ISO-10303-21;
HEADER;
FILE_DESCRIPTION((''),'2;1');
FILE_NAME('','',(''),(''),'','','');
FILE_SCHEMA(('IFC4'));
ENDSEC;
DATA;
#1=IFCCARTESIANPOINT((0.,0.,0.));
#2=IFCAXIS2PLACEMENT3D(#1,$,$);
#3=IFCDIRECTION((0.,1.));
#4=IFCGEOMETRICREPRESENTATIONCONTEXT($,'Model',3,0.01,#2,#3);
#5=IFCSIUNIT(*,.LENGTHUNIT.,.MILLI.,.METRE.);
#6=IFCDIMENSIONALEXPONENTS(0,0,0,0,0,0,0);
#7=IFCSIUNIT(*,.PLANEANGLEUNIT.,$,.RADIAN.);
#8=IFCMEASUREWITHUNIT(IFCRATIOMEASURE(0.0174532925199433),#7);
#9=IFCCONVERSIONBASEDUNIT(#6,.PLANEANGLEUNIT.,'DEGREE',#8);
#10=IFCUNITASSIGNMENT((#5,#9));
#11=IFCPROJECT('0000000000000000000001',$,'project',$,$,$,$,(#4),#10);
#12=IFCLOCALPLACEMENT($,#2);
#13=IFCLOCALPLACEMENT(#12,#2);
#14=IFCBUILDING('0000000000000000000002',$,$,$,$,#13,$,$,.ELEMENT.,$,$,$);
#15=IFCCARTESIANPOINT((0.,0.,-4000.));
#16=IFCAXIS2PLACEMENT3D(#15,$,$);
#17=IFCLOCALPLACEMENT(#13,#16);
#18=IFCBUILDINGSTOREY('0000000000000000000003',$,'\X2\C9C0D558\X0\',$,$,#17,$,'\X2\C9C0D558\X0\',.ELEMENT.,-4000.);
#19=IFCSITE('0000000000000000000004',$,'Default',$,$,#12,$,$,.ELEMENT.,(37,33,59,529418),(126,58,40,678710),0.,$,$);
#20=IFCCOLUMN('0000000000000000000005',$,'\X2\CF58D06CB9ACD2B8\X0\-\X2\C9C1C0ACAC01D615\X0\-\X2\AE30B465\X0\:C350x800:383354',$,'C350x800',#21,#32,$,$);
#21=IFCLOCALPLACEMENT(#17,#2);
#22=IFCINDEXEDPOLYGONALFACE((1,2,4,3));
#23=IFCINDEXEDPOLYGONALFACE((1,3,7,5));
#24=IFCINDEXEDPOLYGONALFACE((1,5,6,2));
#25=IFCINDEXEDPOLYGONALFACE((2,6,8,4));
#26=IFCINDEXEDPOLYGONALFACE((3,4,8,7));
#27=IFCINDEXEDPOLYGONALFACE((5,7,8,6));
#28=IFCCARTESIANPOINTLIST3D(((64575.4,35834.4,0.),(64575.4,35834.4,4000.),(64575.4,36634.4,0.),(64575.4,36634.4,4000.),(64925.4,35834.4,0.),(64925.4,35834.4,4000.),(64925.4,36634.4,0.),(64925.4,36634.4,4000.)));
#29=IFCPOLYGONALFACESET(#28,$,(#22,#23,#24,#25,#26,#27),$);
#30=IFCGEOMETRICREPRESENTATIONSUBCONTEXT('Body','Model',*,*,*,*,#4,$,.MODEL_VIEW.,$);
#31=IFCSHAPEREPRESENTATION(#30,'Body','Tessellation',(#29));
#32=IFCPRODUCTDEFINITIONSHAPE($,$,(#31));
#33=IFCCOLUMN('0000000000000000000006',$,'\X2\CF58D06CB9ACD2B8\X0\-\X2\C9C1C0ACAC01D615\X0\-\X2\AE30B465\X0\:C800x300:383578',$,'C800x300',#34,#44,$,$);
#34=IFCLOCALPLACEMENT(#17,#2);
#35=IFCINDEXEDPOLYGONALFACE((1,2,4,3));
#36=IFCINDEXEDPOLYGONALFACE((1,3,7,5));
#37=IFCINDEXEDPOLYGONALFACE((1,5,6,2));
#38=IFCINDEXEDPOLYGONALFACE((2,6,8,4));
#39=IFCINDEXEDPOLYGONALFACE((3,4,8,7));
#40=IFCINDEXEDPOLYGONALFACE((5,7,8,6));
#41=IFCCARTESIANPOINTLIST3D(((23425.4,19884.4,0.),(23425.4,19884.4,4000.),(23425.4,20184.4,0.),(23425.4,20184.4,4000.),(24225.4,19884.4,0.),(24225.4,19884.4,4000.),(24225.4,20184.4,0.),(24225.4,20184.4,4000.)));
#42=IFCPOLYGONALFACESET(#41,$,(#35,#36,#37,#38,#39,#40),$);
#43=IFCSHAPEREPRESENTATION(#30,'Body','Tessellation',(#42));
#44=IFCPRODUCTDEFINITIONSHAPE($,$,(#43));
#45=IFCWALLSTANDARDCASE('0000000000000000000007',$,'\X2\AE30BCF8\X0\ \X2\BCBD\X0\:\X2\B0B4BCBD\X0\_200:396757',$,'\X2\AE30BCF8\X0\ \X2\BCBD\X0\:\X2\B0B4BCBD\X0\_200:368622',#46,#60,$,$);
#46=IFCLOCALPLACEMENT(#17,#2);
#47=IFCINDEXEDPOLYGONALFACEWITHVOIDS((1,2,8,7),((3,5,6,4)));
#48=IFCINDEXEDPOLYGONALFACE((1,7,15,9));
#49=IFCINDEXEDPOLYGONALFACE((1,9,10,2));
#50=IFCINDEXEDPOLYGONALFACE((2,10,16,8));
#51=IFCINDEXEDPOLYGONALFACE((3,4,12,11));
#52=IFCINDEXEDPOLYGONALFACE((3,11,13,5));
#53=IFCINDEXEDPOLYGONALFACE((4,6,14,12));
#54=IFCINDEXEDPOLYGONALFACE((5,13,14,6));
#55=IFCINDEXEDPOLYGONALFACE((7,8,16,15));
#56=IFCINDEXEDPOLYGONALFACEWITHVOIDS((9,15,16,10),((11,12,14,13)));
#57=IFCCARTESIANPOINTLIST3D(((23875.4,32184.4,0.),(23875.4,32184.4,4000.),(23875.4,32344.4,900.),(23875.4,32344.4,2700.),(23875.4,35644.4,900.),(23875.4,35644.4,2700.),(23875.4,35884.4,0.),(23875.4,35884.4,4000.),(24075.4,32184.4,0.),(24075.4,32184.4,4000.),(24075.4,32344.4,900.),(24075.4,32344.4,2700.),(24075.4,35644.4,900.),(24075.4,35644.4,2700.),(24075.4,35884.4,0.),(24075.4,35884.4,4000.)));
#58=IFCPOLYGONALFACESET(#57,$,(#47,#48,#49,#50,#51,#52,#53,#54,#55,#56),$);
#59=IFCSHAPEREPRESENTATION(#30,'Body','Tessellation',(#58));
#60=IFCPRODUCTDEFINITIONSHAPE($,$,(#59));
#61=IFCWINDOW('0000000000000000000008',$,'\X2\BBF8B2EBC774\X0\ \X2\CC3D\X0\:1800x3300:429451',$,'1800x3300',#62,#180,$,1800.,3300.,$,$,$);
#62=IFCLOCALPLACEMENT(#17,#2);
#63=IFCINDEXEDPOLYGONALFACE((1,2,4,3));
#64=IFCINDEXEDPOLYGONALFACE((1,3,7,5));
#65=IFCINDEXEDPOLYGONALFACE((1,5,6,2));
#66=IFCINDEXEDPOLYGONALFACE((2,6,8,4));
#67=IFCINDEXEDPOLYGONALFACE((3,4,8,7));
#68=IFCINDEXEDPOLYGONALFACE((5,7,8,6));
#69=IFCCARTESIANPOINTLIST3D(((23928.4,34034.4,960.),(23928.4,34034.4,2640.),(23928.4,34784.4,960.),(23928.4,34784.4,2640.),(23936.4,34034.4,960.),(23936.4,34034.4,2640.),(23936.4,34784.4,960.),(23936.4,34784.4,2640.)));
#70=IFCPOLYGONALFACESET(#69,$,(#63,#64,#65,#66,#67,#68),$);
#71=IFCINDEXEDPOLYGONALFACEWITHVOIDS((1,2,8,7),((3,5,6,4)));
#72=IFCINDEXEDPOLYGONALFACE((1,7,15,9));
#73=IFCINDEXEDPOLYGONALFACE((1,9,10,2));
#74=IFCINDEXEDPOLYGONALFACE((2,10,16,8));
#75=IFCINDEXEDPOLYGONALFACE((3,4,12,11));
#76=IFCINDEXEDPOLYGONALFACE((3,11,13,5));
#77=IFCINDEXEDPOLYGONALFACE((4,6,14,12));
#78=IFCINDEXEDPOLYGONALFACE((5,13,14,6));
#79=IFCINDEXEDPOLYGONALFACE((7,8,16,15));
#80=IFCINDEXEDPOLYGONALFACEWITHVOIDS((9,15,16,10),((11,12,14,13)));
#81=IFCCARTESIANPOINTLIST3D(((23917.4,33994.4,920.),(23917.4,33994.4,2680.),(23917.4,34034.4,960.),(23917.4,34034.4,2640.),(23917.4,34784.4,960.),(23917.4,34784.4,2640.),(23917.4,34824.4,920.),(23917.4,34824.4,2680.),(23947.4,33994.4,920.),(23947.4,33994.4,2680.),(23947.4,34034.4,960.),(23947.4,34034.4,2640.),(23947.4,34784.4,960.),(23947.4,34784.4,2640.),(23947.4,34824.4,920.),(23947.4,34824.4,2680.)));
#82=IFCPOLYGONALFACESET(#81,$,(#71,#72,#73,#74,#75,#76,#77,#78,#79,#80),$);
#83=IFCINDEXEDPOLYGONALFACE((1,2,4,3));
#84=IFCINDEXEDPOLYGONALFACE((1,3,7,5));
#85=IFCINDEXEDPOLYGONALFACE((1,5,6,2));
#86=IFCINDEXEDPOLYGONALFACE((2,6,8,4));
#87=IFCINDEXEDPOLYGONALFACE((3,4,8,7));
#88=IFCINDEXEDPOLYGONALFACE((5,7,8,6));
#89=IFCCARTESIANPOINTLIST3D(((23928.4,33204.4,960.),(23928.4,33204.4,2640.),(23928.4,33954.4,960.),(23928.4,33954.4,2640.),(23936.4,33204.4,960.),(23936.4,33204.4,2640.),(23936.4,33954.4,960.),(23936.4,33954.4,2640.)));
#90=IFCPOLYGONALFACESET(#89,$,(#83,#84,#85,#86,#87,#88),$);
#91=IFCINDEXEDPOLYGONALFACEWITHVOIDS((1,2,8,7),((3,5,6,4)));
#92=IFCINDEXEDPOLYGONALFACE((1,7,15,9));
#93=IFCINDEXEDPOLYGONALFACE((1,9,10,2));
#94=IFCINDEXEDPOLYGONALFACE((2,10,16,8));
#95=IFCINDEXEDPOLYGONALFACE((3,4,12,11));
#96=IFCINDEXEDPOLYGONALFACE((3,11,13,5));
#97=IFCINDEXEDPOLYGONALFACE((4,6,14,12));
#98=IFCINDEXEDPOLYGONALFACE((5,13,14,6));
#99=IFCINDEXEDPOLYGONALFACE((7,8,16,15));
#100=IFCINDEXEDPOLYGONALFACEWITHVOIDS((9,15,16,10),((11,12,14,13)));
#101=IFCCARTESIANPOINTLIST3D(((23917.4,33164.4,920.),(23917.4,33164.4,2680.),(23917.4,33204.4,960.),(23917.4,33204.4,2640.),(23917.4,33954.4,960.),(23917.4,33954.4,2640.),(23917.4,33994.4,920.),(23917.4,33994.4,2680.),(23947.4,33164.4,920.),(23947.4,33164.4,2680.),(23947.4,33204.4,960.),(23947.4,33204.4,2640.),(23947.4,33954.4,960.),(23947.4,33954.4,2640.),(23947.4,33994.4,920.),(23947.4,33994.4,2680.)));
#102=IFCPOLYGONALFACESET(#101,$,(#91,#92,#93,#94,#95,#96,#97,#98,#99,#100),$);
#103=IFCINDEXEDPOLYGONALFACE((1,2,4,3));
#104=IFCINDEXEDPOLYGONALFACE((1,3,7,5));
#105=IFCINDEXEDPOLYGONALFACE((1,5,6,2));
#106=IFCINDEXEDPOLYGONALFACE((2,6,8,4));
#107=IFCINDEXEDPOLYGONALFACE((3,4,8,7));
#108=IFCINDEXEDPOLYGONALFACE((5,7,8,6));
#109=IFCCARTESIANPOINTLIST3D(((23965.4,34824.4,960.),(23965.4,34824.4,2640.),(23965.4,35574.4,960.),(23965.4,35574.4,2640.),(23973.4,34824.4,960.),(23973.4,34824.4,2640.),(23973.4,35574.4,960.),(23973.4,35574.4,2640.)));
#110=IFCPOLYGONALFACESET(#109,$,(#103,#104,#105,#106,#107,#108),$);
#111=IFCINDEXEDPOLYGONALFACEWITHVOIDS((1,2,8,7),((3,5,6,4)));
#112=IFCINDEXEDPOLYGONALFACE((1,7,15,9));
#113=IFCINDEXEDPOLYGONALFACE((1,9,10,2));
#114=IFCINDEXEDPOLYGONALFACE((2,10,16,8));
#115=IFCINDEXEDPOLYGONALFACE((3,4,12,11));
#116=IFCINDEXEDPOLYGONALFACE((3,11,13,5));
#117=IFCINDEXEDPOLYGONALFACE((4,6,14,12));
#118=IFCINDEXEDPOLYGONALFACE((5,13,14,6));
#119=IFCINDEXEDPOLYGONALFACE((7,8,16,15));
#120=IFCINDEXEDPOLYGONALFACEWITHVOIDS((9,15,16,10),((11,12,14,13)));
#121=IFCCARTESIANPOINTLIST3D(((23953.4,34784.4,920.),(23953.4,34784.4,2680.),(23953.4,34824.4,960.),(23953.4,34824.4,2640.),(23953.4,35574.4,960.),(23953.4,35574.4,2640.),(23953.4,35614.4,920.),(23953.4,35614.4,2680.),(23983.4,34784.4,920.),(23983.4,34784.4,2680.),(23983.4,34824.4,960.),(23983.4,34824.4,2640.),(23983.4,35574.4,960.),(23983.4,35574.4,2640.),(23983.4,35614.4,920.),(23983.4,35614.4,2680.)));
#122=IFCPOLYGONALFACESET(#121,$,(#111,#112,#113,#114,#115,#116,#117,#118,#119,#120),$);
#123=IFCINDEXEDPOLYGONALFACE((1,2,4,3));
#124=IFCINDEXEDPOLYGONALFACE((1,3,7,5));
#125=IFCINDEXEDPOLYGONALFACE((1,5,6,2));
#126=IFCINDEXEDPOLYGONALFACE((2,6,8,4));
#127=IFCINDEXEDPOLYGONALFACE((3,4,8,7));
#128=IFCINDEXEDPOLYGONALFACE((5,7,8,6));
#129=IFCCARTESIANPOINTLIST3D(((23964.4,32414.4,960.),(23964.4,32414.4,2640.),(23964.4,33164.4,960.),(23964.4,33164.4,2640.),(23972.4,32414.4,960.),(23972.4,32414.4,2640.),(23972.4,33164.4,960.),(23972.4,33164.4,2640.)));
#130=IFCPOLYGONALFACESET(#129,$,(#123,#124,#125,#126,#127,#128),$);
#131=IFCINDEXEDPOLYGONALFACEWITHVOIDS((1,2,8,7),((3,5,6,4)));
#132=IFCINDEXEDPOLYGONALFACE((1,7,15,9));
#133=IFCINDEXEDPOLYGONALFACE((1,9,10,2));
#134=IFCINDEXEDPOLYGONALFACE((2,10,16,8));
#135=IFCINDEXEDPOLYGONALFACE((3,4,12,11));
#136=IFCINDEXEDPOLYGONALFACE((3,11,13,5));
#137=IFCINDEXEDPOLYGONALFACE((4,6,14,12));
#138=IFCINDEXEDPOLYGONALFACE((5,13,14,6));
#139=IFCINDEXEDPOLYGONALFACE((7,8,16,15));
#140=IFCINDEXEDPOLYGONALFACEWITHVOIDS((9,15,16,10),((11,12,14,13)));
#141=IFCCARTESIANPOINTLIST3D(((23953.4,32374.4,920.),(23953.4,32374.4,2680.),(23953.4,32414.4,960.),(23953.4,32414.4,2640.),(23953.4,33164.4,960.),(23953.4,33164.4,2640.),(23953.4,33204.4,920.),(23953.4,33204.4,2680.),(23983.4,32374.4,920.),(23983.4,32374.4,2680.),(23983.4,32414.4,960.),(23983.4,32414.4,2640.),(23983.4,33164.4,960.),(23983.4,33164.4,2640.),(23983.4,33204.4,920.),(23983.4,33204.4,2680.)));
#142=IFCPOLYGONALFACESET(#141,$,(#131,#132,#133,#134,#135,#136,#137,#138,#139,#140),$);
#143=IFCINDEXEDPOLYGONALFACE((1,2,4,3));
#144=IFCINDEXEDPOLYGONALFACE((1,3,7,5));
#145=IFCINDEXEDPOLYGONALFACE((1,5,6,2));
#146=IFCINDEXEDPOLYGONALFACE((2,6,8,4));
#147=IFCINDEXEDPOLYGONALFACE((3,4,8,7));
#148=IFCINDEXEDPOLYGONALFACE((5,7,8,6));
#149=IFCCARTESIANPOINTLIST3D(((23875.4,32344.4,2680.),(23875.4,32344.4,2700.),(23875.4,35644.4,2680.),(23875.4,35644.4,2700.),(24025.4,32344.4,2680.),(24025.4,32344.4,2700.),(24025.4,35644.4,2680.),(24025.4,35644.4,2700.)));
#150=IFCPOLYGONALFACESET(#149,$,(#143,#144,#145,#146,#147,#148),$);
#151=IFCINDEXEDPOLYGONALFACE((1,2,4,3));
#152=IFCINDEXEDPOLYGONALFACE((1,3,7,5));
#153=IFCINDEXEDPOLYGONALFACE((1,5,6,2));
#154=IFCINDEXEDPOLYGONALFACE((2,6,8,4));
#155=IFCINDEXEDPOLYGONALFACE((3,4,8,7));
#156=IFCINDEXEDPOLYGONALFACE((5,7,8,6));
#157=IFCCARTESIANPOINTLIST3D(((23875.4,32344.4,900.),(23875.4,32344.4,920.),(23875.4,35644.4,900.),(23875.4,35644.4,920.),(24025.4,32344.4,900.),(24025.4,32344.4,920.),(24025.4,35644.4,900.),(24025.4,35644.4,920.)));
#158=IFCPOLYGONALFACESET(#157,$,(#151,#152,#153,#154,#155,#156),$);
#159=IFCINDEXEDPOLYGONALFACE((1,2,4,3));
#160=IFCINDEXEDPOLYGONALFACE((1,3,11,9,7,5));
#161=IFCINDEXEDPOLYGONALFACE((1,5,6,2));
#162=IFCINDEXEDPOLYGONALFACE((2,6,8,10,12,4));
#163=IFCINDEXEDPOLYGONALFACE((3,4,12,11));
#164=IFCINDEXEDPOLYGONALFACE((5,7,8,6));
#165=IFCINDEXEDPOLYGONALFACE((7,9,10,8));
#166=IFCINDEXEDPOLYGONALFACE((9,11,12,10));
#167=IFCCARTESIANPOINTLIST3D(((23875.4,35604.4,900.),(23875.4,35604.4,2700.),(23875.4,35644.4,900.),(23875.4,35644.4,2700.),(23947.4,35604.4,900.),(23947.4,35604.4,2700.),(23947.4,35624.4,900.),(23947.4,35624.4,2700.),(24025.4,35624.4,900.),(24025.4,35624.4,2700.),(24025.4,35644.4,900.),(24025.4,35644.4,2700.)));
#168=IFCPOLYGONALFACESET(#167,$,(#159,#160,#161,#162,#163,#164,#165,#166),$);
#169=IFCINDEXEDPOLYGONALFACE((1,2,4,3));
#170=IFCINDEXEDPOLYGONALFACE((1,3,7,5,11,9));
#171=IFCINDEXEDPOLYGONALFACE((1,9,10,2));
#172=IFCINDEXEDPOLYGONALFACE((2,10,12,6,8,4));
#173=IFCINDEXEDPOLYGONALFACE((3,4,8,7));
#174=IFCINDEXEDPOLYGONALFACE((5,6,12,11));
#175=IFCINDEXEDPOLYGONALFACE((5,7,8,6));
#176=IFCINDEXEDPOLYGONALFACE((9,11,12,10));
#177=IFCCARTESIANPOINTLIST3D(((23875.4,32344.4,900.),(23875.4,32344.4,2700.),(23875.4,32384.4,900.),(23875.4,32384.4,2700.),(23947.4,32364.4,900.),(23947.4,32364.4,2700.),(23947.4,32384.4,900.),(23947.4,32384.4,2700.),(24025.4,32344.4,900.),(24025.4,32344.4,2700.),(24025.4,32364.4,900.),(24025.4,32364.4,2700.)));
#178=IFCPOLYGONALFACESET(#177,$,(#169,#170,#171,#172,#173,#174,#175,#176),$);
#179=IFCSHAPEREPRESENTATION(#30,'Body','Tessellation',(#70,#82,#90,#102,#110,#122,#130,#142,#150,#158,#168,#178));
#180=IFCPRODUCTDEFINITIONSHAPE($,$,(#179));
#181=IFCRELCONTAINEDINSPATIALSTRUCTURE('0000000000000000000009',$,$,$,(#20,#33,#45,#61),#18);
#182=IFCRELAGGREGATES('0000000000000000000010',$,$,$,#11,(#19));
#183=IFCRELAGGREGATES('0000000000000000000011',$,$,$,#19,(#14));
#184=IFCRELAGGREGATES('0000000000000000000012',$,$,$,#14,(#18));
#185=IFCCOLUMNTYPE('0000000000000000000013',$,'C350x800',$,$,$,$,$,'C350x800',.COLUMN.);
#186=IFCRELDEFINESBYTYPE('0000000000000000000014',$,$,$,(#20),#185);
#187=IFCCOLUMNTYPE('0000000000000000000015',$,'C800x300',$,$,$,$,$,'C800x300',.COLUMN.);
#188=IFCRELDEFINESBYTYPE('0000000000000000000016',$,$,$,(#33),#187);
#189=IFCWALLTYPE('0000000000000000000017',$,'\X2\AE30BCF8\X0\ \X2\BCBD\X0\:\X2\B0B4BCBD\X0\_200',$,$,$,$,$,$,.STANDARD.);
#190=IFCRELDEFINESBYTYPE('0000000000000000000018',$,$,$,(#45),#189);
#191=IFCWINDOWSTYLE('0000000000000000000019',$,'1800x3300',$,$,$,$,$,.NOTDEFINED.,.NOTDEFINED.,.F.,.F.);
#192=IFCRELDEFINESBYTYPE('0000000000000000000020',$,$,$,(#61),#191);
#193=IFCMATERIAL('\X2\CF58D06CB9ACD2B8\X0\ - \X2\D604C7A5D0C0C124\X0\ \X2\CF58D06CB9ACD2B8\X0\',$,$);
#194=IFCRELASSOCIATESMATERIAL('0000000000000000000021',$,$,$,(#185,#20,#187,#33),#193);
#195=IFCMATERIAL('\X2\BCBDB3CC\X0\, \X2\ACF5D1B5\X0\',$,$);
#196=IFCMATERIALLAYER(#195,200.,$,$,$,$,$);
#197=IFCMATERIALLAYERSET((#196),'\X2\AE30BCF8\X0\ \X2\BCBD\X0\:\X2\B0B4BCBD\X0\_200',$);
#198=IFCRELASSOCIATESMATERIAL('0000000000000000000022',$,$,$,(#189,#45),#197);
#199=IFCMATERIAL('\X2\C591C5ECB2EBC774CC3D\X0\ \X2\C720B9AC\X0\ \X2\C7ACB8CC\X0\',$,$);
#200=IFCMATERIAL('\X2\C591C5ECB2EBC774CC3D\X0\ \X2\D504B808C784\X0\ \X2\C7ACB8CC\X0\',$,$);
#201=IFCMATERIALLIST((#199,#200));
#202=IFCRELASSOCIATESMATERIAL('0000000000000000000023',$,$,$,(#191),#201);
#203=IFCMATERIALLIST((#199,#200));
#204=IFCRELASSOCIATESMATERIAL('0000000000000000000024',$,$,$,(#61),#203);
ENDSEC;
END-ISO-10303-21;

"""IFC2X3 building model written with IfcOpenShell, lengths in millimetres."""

from ifc_helpers import new_model, entity, si_unit, converted_unit, direction, frame, frame_2d, origin, origin_2d_with_axis, place, context, subcontext, project, spatial, polyline, rectangle, outline, extrude, source, transform, mapped, material, material_list, layer, layer_set, layer_usage, type_object, type_shapes, element, fill, save


model = new_model("IFC2X3")

# Units and contexts
model_context = context("Model", 3, precision=0.01, world=origin(), true_north=direction((0.0, 1.0)))
body_context = subcontext(model_context, "Body", "Model", "MODEL_VIEW")
ifc_project = project(units=[si_unit("LENGTHUNIT", "METRE", prefix="MILLI"), converted_unit("PLANEANGLEUNIT", "DEGREE", entity("IfcRatioMeasure", 0.0174532925199433), si_unit("PLANEANGLEUNIT", "RADIAN"), dimensions=[0, 0, 0, 0, 0, 0, 0])], contexts=[model_context])

# Site, building, storey
site_placement = place(None, origin())
site = spatial("IfcSite", under=ifc_project, at=site_placement, Name="Default", CompositionType="ELEMENT", RefLatitude=(37, 33, 59, 529418), RefLongitude=(126, 58, 40, 678710), RefElevation=0.0)
building_placement = place(site_placement, origin())
building = spatial("IfcBuilding", under=site, at=building_placement, CompositionType="ELEMENT")
storey_placement = place(building_placement, frame((0.0, 0.0, -4000.0)))
storey = spatial("IfcBuildingStorey", under=building, at=storey_placement, Name="지하", LongName="지하", CompositionType="ELEMENT", Elevation=-4000.0)

# Columns
ifc_material_1 = material(Name="콘크리트 - 현장타설 콘크리트")
column_type_1 = type_object("IfcColumnType", Name="C350x800", ElementType="C350x800", PredefinedType="COLUMN", material=ifc_material_1)
shared_shape_1 = source(origin(), body_context, "Body", "SweptSolid", [
    extrude(rectangle(XDim=800.0, YDim=350.0, at=frame_2d((0.0, 0.0), x_axis=(1.0, 0.0))), frame((64750.4, 36234.4, -4000.0), z_axis=(0.0, 0.0, 1.0), x_axis=(0.0, -1.0, 0.0)), (0.0, 0.0, 1.0), 4000.0),
])
type_shapes(column_type_1, [shared_shape_1])
column_1_placement = place(storey_placement, frame((0.0, 0.0, 4000.0)))
element("IfcColumn", 1, at=column_1_placement, inside=storey, type_object=column_type_1, material=ifc_material_1, Name="콘크리트-직사각형-기둥:C350x800:383354", ObjectType="C350x800", context=body_context, shape_type="MappedRepresentation", body=[
    mapped(shared_shape_1, transform((0.0, 0.0, 0.0), scale=1.0)),
])
column_type_2 = type_object("IfcColumnType", Name="C800x300", ElementType="C800x300", PredefinedType="COLUMN", material=ifc_material_1)
shared_shape_2 = source(origin(), body_context, "Body", "SweptSolid", [
    extrude(rectangle(XDim=300.0, YDim=800.0, at=origin_2d_with_axis()), frame((23825.4, 20034.4, -4000.0), z_axis=(0.0, 0.0, 1.0), x_axis=(0.0, -1.0, 0.0)), (0.0, 0.0, 1.0), 4000.0),
])
type_shapes(column_type_2, [shared_shape_2])
column_2_placement = place(storey_placement, frame((0.0, 0.0, 4000.0)))
element("IfcColumn", 2, at=column_2_placement, inside=storey, type_object=column_type_2, material=ifc_material_1, Name="콘크리트-직사각형-기둥:C800x300:383578", ObjectType="C800x300", context=body_context, shape_type="MappedRepresentation", body=[
    mapped(shared_shape_2, transform((0.0, 0.0, 0.0), scale=1.0)),
])

# Wall, opening, window
ifc_material_2 = material(Name="벽돌, 공통")
ifc_layer_1 = layer(ifc_material_2, 200.0)
ifc_layer_set_1 = layer_set([ifc_layer_1], Name="기본 벽:내벽_200")
ifc_layer_usage_1 = layer_usage(ifc_layer_set_1, "AXIS2", "NEGATIVE", 100.0)
wall_type_1 = type_object("IfcWallType", Name="기본 벽:내벽_200", PredefinedType="STANDARD", material=ifc_layer_set_1)
wall_1_placement = place(storey_placement, frame((23975.4, 35884.4, 0.0), z_axis=(0.0, 0.0, 1.0), x_axis=(0.0, -1.0, 0.0)))
wall_1 = element("IfcWallStandardCase", 3, at=wall_1_placement, inside=storey, type_object=wall_type_1, material=ifc_layer_usage_1, Name="기본 벽:내벽_200:396757", ObjectType="기본 벽:내벽_200:368622", context=body_context, shape_type="SweptSolid", body=[
    extrude(rectangle(XDim=3700.0, YDim=200.0, at=frame_2d((1850.0, 0.0), x_axis=(-1.0, 0.0))), origin(), (0.0, 0.0, 1.0), 4000.0),
])
opening_1_placement = place(wall_1_placement, frame((3540.0, 100.0, 900.0)))
opening_1 = element("IfcOpeningElement", 4, at=opening_1_placement, cuts=wall_1, ObjectType="Opening", context=body_context, shape_type="SweptSolid", body=[
    extrude(rectangle(XDim=1800.0, YDim=3300.0, at=frame_2d((900.0, 1650.0), x_axis=(1.0, 0.0))), frame((0.0, 0.0, 0.0), z_axis=(0.0, -1.0, 0.0), x_axis=(0.0, 0.0, 1.0)), (0.0, 0.0, 1.0), 200.0),
])
ifc_material_3 = material(Name="양여닫이창 유리 재료")
ifc_material_4 = material(Name="양여닫이창 프레임 재료")
ifc_material_list_1 = material_list([ifc_material_3, ifc_material_4])
ifc_material_list_2 = material_list([ifc_material_3, ifc_material_4])
window_style = type_object("IfcWindowStyle", Name="1800x3300", ConstructionType="NOTDEFINED", OperationType="NOTDEFINED", ParameterTakesPrecedence=False, Sizeable=False, material=ifc_material_list_2)
shared_shape_3 = source(origin(), body_context, "Body", "SweptSolid", [
    extrude(rectangle(XDim=8.0, YDim=750.0, at=frame_2d((0.0, 0.0), x_axis=(1.0, 0.0))), frame((2065.0, 143.0, 60.0), z_axis=(0.0, 0.0, 1.0), x_axis=(0.0, 1.0, 0.0)), (0.0, 0.0, 1.0), 1680.0),
    extrude(outline(polyline([(-880.0, -415.0), (880.0, -415.0), (880.0, 415.0), (-880.0, 415.0), (-880.0, -415.0)]), holes=[polyline([(840.0, -375.0), (-840.0, -375.0), (-840.0, 375.0), (840.0, 375.0), (840.0, -375.0)])]), frame((2065.0, 128.0, 900.0), z_axis=(0.0, 1.0, 0.0), x_axis=(0.0, 0.0, -1.0)), (0.0, 0.0, 1.0), 30.0),
    extrude(rectangle(XDim=8.0, YDim=750.0, at=frame_2d((0.0, 0.0), x_axis=(1.0, 0.0))), frame((1235.0, 143.0, 60.0), z_axis=(0.0, 0.0, 1.0), x_axis=(0.0, 1.0, 0.0)), (0.0, 0.0, 1.0), 1680.0),
    extrude(outline(polyline([(-880.0, -415.0), (880.0, -415.0), (880.0, 415.0), (-880.0, 415.0), (-880.0, -415.0)]), holes=[polyline([(840.0, -375.0), (-840.0, -375.0), (-840.0, 375.0), (840.0, 375.0), (840.0, -375.0)])]), frame((1235.0, 128.0, 900.0), z_axis=(0.0, 1.0, 0.0), x_axis=(0.0, 0.0, -1.0)), (0.0, 0.0, 1.0), 30.0),
    extrude(rectangle(XDim=8.0, YDim=750.0, at=frame_2d((0.0, 0.0), x_axis=(1.0, 0.0))), frame((2855.0, 106.0, 60.0), z_axis=(0.0, 0.0, 1.0), x_axis=(0.0, 1.0, 0.0)), (0.0, 0.0, 1.0), 1680.0),
    extrude(outline(polyline([(-880.0, -415.0), (880.0, -415.0), (880.0, 415.0), (-880.0, 415.0), (-880.0, -415.0)]), holes=[polyline([(840.0, -375.0), (-840.0, -375.0), (-840.0, 375.0), (840.0, 375.0), (840.0, -375.0)])]), frame((2855.0, 92.0, 900.0), z_axis=(0.0, 1.0, 0.0), x_axis=(0.0, 0.0, -1.0)), (0.0, 0.0, 1.0), 30.0),
    extrude(rectangle(XDim=8.0, YDim=750.0, at=origin_2d_with_axis()), frame((445.0, 107.0, 60.0), z_axis=(0.0, 0.0, 1.0), x_axis=(0.0, 1.0, 0.0)), (0.0, 0.0, 1.0), 1680.0),
    extrude(outline(polyline([(-880.0, -415.0), (880.0, -415.0), (880.0, 415.0), (-880.0, 415.0), (-880.0, -415.0)]), holes=[polyline([(840.0, -375.0), (-840.0, -375.0), (-840.0, 375.0), (840.0, 375.0), (840.0, -375.0)])]), frame((445.0, 92.0, 900.0), z_axis=(0.0, 1.0, 0.0), x_axis=(0.0, 0.0, -1.0)), (0.0, 0.0, 1.0), 30.0),
    extrude(rectangle(XDim=3300.0, YDim=150.0, at=origin_2d_with_axis()), frame((1650.0, 125.0, 1780.0), z_axis=(0.0, 0.0, 1.0), x_axis=(-1.0, 0.0, 0.0)), (0.0, 0.0, 1.0), 20.0),
    extrude(rectangle(XDim=3300.0, YDim=150.0, at=origin_2d_with_axis()), frame((1650.0, 125.0, 0.0), z_axis=(0.0, 0.0, 1.0), x_axis=(-1.0, 0.0, 0.0)), (0.0, 0.0, 1.0), 20.0),
    extrude(outline(polyline([(-74.0, -20.0), (-2.0, -20.0), (-2.0, 0.0), (76.0, 0.0), (76.0, 20.0), (-74.0, 20.0), (-74.0, -20.0)])), frame((3280.0, 126.0, 0.0), z_axis=(0.0, 0.0, 1.0), x_axis=(0.0, -1.0, 0.0)), (0.0, 0.0, 1.0), 1800.0),
    extrude(outline(polyline([(-20.0, -74.0), (20.0, -74.0), (20.0, 76.0), (0.0, 76.0), (0.0, -2.0), (-20.0, -2.0), (-20.0, -74.0)])), frame((20.0, 126.0, 0.0), z_axis=(0.0, 0.0, 1.0), x_axis=(-1.0, 0.0, 0.0)), (0.0, 0.0, 1.0), 1800.0),
])
type_shapes(window_style, [shared_shape_3])
window_1_placement = place(opening_1_placement, frame((0.0, 0.0, 0.0), z_axis=(0.0, 0.0, 1.0), x_axis=(-1.0, 0.0, 0.0)))
window_1 = element("IfcWindow", 5, at=window_1_placement, inside=storey, type_object=window_style, material=ifc_material_list_1, Name="미닫이 창:1800x3300:429451", ObjectType="1800x3300", OverallHeight=1800.0, OverallWidth=3300.0, context=body_context, shape_type="MappedRepresentation", body=[
    mapped(shared_shape_3, transform((0.0, 0.0, 0.0), scale=1.0)),
])
fill(opening_1, window_1)

save(model, "model.ifc")
